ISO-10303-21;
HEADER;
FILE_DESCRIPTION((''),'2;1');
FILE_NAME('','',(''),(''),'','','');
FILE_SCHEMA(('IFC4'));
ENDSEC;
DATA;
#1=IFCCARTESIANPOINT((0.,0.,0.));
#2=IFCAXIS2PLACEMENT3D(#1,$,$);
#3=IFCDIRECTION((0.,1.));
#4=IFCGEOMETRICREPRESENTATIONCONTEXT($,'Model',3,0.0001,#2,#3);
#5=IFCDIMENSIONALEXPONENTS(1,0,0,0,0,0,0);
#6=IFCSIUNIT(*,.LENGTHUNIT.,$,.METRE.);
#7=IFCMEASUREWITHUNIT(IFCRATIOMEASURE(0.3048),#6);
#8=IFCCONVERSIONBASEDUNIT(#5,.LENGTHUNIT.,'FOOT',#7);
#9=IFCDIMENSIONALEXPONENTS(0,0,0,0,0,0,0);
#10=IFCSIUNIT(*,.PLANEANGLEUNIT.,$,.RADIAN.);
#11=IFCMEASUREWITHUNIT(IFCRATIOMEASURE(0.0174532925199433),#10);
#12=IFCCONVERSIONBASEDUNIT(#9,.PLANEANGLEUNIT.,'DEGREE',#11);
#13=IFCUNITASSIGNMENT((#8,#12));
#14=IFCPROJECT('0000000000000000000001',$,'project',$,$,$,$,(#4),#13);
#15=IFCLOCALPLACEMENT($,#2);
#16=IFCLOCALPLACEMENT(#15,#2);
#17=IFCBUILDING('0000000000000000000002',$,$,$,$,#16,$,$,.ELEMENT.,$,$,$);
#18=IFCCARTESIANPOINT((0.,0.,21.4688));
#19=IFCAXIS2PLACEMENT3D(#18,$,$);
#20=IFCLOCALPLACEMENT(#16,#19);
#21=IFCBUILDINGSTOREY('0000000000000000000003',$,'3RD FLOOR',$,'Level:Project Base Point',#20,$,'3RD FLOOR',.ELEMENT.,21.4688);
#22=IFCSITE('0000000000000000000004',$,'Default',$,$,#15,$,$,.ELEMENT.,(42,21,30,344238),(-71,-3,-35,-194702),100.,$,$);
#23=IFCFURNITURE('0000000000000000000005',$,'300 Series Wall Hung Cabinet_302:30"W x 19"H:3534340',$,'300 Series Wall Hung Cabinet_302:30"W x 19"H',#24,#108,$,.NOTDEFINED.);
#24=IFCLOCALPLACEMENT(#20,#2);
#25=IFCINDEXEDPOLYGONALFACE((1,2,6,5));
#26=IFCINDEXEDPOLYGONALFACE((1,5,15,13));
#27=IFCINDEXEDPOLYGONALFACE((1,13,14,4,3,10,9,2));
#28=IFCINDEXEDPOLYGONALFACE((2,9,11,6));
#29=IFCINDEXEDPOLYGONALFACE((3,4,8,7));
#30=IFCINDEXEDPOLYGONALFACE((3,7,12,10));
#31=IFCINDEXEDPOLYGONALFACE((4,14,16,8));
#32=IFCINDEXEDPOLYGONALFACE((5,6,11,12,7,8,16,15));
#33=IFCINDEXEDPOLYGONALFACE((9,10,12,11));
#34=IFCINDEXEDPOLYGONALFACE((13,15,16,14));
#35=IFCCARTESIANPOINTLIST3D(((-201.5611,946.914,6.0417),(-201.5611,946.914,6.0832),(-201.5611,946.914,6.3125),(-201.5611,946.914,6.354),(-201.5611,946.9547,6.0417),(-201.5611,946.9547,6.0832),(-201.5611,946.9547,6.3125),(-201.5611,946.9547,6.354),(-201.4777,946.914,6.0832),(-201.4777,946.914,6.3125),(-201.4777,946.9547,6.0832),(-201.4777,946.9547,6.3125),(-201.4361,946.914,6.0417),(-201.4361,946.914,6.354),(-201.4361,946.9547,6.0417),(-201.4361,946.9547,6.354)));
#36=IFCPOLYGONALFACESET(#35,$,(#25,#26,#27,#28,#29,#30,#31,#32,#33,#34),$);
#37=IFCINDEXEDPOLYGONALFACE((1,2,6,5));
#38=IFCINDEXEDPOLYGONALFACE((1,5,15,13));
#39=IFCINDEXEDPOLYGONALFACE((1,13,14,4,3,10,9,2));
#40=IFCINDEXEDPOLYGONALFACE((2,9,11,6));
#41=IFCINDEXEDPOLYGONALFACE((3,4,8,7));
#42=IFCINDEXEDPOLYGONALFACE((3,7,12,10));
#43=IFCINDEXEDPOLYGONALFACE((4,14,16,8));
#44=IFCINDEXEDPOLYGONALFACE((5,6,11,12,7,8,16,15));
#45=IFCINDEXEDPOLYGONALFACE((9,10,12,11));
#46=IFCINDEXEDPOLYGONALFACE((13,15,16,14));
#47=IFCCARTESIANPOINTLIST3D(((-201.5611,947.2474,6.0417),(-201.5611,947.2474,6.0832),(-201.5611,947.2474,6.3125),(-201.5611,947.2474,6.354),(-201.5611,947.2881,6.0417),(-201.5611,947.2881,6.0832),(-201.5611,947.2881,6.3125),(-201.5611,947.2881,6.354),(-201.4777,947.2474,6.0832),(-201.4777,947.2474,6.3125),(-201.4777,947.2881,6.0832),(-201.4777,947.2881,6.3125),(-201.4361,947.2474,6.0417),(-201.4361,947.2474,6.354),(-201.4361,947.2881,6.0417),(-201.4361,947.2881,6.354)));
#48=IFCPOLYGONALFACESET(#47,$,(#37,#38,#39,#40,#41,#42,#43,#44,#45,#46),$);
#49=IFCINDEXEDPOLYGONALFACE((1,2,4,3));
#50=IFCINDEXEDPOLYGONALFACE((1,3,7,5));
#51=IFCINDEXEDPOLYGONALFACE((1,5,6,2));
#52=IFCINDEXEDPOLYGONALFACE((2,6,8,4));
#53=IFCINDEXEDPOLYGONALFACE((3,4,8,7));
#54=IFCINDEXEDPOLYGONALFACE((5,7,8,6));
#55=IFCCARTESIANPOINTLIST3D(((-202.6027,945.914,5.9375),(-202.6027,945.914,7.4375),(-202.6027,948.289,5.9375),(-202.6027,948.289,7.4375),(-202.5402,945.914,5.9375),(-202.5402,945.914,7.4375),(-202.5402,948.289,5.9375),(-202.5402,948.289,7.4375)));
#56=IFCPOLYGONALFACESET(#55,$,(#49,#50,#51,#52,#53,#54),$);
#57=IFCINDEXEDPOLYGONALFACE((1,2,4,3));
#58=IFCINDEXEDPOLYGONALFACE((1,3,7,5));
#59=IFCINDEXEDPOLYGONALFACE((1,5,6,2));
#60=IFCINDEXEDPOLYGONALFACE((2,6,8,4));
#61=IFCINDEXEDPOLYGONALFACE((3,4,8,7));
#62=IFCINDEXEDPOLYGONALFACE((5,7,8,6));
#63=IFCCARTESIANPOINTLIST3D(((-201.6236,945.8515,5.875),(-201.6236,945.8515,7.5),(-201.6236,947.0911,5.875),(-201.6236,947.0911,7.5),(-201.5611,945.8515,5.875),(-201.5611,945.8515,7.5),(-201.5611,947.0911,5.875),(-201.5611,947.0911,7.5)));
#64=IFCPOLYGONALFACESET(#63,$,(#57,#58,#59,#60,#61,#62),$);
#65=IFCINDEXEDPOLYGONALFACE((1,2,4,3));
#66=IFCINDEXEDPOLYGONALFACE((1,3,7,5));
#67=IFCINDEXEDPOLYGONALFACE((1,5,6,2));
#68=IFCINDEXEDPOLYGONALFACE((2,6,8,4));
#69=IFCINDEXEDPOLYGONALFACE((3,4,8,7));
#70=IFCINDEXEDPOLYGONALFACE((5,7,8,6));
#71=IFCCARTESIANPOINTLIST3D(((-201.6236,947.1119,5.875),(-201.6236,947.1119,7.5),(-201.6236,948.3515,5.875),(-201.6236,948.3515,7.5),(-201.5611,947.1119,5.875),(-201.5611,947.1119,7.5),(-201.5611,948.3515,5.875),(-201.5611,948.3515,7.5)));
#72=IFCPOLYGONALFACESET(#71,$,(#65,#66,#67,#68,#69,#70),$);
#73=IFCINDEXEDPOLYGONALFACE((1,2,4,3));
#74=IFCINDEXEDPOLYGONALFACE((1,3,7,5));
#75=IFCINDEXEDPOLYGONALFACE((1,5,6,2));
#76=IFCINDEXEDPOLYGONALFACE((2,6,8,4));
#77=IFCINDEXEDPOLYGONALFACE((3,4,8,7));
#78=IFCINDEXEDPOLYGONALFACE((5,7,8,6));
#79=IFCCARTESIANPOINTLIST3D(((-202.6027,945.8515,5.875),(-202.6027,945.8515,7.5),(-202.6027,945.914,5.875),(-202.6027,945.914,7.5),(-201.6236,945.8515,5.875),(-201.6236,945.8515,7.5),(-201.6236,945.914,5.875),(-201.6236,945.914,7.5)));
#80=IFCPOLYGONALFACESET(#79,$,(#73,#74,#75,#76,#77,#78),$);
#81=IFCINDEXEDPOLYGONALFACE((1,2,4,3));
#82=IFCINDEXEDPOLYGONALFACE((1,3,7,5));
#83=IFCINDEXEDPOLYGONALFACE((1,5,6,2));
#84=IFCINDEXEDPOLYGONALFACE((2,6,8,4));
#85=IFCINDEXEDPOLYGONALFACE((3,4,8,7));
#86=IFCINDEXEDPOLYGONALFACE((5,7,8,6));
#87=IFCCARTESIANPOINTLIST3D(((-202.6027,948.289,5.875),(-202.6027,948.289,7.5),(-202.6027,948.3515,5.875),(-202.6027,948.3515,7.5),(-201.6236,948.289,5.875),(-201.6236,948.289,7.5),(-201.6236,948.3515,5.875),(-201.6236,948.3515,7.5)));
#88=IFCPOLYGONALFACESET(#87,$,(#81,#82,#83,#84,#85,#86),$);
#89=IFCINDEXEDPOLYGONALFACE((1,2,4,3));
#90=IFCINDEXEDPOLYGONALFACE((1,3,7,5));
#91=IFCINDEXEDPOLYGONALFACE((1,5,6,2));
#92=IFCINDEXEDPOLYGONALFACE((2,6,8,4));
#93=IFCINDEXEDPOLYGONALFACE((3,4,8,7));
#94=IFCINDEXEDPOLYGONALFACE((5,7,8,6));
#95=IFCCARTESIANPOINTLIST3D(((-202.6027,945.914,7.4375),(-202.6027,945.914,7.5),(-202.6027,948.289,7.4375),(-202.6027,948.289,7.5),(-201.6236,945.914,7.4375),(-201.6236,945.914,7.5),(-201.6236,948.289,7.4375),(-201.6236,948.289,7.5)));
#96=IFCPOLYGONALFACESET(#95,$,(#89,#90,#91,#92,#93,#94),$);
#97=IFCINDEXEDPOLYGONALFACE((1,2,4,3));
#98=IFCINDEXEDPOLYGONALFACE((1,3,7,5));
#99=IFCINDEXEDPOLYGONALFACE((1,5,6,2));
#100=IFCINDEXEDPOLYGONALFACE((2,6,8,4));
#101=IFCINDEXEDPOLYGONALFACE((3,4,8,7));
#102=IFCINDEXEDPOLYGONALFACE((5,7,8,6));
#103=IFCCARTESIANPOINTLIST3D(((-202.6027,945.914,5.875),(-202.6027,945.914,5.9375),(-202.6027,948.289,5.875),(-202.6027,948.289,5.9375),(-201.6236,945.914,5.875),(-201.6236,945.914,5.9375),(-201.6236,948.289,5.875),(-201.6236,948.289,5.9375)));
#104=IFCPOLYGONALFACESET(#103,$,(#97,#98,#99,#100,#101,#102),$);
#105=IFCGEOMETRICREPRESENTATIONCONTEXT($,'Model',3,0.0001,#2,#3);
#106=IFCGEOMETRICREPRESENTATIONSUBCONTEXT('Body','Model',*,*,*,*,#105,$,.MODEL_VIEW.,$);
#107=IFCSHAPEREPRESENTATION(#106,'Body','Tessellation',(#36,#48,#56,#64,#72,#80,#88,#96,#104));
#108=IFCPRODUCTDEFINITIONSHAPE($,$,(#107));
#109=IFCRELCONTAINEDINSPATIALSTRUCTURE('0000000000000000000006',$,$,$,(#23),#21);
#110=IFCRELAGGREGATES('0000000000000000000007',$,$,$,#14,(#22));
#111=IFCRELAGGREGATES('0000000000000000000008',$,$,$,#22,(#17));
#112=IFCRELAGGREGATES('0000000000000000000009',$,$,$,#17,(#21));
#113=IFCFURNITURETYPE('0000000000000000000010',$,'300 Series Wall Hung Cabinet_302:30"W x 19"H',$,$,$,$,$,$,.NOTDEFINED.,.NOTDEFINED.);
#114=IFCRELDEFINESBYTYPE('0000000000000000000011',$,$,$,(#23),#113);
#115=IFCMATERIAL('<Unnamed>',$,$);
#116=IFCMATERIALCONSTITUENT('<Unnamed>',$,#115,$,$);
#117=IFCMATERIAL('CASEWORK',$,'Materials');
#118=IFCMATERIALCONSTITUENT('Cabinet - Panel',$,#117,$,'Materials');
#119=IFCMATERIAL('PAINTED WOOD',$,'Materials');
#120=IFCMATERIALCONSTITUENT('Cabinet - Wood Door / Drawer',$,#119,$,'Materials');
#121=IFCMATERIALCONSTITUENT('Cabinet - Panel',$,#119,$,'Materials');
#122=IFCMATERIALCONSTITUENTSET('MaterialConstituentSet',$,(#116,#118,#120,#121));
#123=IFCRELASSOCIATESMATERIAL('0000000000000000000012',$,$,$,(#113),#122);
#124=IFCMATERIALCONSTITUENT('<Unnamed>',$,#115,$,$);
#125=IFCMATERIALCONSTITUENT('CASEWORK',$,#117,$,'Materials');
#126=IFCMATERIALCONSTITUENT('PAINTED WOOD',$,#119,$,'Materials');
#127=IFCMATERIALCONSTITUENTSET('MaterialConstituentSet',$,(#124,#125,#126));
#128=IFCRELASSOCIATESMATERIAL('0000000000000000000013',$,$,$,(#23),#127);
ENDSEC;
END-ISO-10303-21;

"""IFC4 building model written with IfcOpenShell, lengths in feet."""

from ifc_helpers import new_model, entity, si_unit, converted_unit, direction, frame, frame_2d, origin, origin_2d_with_axis, place, context, subcontext, project, spatial, polyline, rectangle, outline, extrude, source, transform, mapped, material, constituent, constituent_set, type_object, type_shapes, element, save


model = new_model("IFC4")

# Units and contexts
model_context_1 = context("Model", 3, precision=0.0001, world=origin(), true_north=direction((0.0, 1.0)))
model_context_2 = context("Model", 3, precision=0.0001, world=origin(), true_north=direction((0.0, 1.0)))
body_context = subcontext(model_context_2, "Body", "Model", "MODEL_VIEW")
ifc_project = project(units=[converted_unit("LENGTHUNIT", "FOOT", entity("IfcRatioMeasure", 0.3048), si_unit("LENGTHUNIT", "METRE"), dimensions=[1, 0, 0, 0, 0, 0, 0]), converted_unit("PLANEANGLEUNIT", "DEGREE", entity("IfcRatioMeasure", 0.0174532925199433), si_unit("PLANEANGLEUNIT", "RADIAN"), dimensions=[0, 0, 0, 0, 0, 0, 0])], contexts=[model_context_1])

# Site, building, storey
site_placement = place(None, origin())
site = spatial("IfcSite", under=ifc_project, at=site_placement, Name="Default", CompositionType="ELEMENT", RefLatitude=(42, 21, 30, 344238), RefLongitude=(-71, -3, -35, -194702), RefElevation=100.0)
building_placement = place(site_placement, origin())
building = spatial("IfcBuilding", under=site, at=building_placement, CompositionType="ELEMENT")
storey_placement = place(building_placement, frame((0.0, 0.0, 21.4688)))
storey = spatial("IfcBuildingStorey", under=building, at=storey_placement, Name="3RD FLOOR", ObjectType="Level:Project Base Point", LongName="3RD FLOOR", CompositionType="ELEMENT", Elevation=21.4688)

# Furniture
ifc_material_1 = material(Name="CASEWORK", Category="Materials")
ifc_material_2 = material(Name="PAINTED WOOD", Category="Materials")
ifc_material_3 = material(Name="<Unnamed>")
ifc_constituent_1 = constituent(ifc_material_3, Name="<Unnamed>")
ifc_constituent_2 = constituent(ifc_material_1, Name="CASEWORK", Category="Materials")
ifc_constituent_3 = constituent(ifc_material_2, Name="PAINTED WOOD", Category="Materials")
ifc_constituent_set_1 = constituent_set(constituents=[ifc_constituent_1, ifc_constituent_2, ifc_constituent_3], Name="MaterialConstituentSet")
ifc_constituent_4 = constituent(ifc_material_3, Name="<Unnamed>")
ifc_constituent_5 = constituent(ifc_material_1, Name="Cabinet - Panel", Category="Materials")
ifc_constituent_6 = constituent(ifc_material_2, Name="Cabinet - Wood Door / Drawer", Category="Materials")
ifc_constituent_7 = constituent(ifc_material_2, Name="Cabinet - Panel", Category="Materials")
ifc_constituent_set_2 = constituent_set(constituents=[ifc_constituent_4, ifc_constituent_5, ifc_constituent_6, ifc_constituent_7], Name="MaterialConstituentSet")
furniture_type_1 = type_object("IfcFurnitureType", Name="300 Series Wall Hung Cabinet_302:30\"W x 19\"H", AssemblyPlace="NOTDEFINED", PredefinedType="NOTDEFINED", material=ifc_constituent_set_2)
shared_shape_1 = source(origin(), body_context, "Body", "SweptSolid", [
    extrude(outline(polyline([(0.1146, -0.0521), (0.1562, -0.0521), (0.1562, 0.0729), (-0.1562, 0.0729), (-0.1562, -0.0521), (-0.1146, -0.0521), (-0.1146, 0.0313), (0.1146, 0.0313), (0.1146, -0.0521)])), frame((1.0625, 0.0729, 0.3229), z_axis=(1.0, 0.0, 0.0), x_axis=(0.0, 0.0, 1.0)), (0.0, 0.0, 1.0), 0.0407),
    extrude(outline(polyline([(0.1146, -0.0521), (0.1562, -0.0521), (0.1562, 0.0729), (-0.1562, 0.0729), (-0.1562, -0.0521), (-0.1146, -0.0521), (-0.1146, 0.0313), (0.1146, 0.0313), (0.1146, -0.0521)])), frame((1.3958, 0.0729, 0.3229), z_axis=(1.0, 0.0, 0.0), x_axis=(0.0, 0.0, 1.0)), (0.0, 0.0, 1.0), 0.0407),
    extrude(rectangle(XDim=2.375, YDim=0.0625, at=origin_2d_with_axis()), frame((1.25, 1.1354, 0.0625), z_axis=(0.0, 0.0, 1.0), x_axis=(-1.0, 0.0, 0.0)), (0.0, 0.0, 1.0), 1.5),
    extrude(rectangle(XDim=1.2396, YDim=0.0625, at=origin_2d_with_axis()), frame((0.6198, 0.1562, 0.0), z_axis=(0.0, 0.0, 1.0), x_axis=(-1.0, 0.0, 0.0)), (0.0, 0.0, 1.0), 1.625),
    extrude(rectangle(XDim=1.2396, YDim=0.0625, at=frame_2d((0.0, 0.0), x_axis=(1.0, 0.0))), frame((1.8802, 0.1562, 0.0), z_axis=(0.0, 0.0, 1.0), x_axis=(-1.0, 0.0, 0.0)), (0.0, 0.0, 1.0), 1.625),
    extrude(rectangle(XDim=0.9792, YDim=0.0625, at=frame_2d((0.0, 0.0), x_axis=(1.0, 0.0))), frame((0.0313, 0.677, 0.0), z_axis=(0.0, 0.0, 1.0), x_axis=(0.0, -1.0, 0.0)), (0.0, 0.0, 1.0), 1.625),
    extrude(rectangle(XDim=0.9792, YDim=0.0625, at=frame_2d((0.0, 0.0), x_axis=(1.0, 0.0))), frame((2.4688, 0.677, 0.0), z_axis=(0.0, 0.0, 1.0), x_axis=(0.0, -1.0, 0.0)), (0.0, 0.0, 1.0), 1.625),
    extrude(rectangle(XDim=0.9792, YDim=2.375, at=frame_2d((0.0, 0.0), x_axis=(1.0, 0.0))), frame((1.25, 0.677, 1.5625), z_axis=(0.0, 0.0, 1.0), x_axis=(0.0, 1.0, 0.0)), (0.0, 0.0, 1.0), 0.0625),
    extrude(rectangle(XDim=0.9792, YDim=2.375, at=frame_2d((0.0, 0.0), x_axis=(1.0, 0.0))), frame((1.25, 0.677, 0.0), z_axis=(0.0, 0.0, 1.0), x_axis=(0.0, 1.0, 0.0)), (0.0, 0.0, 1.0), 0.0625),
])
type_shapes(furniture_type_1, [shared_shape_1])
furniture_1_placement = place(storey_placement, frame((-201.4361, 945.8515, 5.875), z_axis=(0.0, 0.0, 1.0), x_axis=(0.0, 1.0, 0.0)))
element("IfcFurniture", 1, at=furniture_1_placement, inside=storey, type_object=furniture_type_1, material=ifc_constituent_set_1, Name="300 Series Wall Hung Cabinet_302:30\"W x 19\"H:3534340", ObjectType="300 Series Wall Hung Cabinet_302:30\"W x 19\"H", PredefinedType="NOTDEFINED", context=body_context, shape_type="MappedRepresentation", body=[
    mapped(shared_shape_1, transform((0.0, 0.0, 0.0), scale=1.0)),
])

save(model, "model.ifc")
